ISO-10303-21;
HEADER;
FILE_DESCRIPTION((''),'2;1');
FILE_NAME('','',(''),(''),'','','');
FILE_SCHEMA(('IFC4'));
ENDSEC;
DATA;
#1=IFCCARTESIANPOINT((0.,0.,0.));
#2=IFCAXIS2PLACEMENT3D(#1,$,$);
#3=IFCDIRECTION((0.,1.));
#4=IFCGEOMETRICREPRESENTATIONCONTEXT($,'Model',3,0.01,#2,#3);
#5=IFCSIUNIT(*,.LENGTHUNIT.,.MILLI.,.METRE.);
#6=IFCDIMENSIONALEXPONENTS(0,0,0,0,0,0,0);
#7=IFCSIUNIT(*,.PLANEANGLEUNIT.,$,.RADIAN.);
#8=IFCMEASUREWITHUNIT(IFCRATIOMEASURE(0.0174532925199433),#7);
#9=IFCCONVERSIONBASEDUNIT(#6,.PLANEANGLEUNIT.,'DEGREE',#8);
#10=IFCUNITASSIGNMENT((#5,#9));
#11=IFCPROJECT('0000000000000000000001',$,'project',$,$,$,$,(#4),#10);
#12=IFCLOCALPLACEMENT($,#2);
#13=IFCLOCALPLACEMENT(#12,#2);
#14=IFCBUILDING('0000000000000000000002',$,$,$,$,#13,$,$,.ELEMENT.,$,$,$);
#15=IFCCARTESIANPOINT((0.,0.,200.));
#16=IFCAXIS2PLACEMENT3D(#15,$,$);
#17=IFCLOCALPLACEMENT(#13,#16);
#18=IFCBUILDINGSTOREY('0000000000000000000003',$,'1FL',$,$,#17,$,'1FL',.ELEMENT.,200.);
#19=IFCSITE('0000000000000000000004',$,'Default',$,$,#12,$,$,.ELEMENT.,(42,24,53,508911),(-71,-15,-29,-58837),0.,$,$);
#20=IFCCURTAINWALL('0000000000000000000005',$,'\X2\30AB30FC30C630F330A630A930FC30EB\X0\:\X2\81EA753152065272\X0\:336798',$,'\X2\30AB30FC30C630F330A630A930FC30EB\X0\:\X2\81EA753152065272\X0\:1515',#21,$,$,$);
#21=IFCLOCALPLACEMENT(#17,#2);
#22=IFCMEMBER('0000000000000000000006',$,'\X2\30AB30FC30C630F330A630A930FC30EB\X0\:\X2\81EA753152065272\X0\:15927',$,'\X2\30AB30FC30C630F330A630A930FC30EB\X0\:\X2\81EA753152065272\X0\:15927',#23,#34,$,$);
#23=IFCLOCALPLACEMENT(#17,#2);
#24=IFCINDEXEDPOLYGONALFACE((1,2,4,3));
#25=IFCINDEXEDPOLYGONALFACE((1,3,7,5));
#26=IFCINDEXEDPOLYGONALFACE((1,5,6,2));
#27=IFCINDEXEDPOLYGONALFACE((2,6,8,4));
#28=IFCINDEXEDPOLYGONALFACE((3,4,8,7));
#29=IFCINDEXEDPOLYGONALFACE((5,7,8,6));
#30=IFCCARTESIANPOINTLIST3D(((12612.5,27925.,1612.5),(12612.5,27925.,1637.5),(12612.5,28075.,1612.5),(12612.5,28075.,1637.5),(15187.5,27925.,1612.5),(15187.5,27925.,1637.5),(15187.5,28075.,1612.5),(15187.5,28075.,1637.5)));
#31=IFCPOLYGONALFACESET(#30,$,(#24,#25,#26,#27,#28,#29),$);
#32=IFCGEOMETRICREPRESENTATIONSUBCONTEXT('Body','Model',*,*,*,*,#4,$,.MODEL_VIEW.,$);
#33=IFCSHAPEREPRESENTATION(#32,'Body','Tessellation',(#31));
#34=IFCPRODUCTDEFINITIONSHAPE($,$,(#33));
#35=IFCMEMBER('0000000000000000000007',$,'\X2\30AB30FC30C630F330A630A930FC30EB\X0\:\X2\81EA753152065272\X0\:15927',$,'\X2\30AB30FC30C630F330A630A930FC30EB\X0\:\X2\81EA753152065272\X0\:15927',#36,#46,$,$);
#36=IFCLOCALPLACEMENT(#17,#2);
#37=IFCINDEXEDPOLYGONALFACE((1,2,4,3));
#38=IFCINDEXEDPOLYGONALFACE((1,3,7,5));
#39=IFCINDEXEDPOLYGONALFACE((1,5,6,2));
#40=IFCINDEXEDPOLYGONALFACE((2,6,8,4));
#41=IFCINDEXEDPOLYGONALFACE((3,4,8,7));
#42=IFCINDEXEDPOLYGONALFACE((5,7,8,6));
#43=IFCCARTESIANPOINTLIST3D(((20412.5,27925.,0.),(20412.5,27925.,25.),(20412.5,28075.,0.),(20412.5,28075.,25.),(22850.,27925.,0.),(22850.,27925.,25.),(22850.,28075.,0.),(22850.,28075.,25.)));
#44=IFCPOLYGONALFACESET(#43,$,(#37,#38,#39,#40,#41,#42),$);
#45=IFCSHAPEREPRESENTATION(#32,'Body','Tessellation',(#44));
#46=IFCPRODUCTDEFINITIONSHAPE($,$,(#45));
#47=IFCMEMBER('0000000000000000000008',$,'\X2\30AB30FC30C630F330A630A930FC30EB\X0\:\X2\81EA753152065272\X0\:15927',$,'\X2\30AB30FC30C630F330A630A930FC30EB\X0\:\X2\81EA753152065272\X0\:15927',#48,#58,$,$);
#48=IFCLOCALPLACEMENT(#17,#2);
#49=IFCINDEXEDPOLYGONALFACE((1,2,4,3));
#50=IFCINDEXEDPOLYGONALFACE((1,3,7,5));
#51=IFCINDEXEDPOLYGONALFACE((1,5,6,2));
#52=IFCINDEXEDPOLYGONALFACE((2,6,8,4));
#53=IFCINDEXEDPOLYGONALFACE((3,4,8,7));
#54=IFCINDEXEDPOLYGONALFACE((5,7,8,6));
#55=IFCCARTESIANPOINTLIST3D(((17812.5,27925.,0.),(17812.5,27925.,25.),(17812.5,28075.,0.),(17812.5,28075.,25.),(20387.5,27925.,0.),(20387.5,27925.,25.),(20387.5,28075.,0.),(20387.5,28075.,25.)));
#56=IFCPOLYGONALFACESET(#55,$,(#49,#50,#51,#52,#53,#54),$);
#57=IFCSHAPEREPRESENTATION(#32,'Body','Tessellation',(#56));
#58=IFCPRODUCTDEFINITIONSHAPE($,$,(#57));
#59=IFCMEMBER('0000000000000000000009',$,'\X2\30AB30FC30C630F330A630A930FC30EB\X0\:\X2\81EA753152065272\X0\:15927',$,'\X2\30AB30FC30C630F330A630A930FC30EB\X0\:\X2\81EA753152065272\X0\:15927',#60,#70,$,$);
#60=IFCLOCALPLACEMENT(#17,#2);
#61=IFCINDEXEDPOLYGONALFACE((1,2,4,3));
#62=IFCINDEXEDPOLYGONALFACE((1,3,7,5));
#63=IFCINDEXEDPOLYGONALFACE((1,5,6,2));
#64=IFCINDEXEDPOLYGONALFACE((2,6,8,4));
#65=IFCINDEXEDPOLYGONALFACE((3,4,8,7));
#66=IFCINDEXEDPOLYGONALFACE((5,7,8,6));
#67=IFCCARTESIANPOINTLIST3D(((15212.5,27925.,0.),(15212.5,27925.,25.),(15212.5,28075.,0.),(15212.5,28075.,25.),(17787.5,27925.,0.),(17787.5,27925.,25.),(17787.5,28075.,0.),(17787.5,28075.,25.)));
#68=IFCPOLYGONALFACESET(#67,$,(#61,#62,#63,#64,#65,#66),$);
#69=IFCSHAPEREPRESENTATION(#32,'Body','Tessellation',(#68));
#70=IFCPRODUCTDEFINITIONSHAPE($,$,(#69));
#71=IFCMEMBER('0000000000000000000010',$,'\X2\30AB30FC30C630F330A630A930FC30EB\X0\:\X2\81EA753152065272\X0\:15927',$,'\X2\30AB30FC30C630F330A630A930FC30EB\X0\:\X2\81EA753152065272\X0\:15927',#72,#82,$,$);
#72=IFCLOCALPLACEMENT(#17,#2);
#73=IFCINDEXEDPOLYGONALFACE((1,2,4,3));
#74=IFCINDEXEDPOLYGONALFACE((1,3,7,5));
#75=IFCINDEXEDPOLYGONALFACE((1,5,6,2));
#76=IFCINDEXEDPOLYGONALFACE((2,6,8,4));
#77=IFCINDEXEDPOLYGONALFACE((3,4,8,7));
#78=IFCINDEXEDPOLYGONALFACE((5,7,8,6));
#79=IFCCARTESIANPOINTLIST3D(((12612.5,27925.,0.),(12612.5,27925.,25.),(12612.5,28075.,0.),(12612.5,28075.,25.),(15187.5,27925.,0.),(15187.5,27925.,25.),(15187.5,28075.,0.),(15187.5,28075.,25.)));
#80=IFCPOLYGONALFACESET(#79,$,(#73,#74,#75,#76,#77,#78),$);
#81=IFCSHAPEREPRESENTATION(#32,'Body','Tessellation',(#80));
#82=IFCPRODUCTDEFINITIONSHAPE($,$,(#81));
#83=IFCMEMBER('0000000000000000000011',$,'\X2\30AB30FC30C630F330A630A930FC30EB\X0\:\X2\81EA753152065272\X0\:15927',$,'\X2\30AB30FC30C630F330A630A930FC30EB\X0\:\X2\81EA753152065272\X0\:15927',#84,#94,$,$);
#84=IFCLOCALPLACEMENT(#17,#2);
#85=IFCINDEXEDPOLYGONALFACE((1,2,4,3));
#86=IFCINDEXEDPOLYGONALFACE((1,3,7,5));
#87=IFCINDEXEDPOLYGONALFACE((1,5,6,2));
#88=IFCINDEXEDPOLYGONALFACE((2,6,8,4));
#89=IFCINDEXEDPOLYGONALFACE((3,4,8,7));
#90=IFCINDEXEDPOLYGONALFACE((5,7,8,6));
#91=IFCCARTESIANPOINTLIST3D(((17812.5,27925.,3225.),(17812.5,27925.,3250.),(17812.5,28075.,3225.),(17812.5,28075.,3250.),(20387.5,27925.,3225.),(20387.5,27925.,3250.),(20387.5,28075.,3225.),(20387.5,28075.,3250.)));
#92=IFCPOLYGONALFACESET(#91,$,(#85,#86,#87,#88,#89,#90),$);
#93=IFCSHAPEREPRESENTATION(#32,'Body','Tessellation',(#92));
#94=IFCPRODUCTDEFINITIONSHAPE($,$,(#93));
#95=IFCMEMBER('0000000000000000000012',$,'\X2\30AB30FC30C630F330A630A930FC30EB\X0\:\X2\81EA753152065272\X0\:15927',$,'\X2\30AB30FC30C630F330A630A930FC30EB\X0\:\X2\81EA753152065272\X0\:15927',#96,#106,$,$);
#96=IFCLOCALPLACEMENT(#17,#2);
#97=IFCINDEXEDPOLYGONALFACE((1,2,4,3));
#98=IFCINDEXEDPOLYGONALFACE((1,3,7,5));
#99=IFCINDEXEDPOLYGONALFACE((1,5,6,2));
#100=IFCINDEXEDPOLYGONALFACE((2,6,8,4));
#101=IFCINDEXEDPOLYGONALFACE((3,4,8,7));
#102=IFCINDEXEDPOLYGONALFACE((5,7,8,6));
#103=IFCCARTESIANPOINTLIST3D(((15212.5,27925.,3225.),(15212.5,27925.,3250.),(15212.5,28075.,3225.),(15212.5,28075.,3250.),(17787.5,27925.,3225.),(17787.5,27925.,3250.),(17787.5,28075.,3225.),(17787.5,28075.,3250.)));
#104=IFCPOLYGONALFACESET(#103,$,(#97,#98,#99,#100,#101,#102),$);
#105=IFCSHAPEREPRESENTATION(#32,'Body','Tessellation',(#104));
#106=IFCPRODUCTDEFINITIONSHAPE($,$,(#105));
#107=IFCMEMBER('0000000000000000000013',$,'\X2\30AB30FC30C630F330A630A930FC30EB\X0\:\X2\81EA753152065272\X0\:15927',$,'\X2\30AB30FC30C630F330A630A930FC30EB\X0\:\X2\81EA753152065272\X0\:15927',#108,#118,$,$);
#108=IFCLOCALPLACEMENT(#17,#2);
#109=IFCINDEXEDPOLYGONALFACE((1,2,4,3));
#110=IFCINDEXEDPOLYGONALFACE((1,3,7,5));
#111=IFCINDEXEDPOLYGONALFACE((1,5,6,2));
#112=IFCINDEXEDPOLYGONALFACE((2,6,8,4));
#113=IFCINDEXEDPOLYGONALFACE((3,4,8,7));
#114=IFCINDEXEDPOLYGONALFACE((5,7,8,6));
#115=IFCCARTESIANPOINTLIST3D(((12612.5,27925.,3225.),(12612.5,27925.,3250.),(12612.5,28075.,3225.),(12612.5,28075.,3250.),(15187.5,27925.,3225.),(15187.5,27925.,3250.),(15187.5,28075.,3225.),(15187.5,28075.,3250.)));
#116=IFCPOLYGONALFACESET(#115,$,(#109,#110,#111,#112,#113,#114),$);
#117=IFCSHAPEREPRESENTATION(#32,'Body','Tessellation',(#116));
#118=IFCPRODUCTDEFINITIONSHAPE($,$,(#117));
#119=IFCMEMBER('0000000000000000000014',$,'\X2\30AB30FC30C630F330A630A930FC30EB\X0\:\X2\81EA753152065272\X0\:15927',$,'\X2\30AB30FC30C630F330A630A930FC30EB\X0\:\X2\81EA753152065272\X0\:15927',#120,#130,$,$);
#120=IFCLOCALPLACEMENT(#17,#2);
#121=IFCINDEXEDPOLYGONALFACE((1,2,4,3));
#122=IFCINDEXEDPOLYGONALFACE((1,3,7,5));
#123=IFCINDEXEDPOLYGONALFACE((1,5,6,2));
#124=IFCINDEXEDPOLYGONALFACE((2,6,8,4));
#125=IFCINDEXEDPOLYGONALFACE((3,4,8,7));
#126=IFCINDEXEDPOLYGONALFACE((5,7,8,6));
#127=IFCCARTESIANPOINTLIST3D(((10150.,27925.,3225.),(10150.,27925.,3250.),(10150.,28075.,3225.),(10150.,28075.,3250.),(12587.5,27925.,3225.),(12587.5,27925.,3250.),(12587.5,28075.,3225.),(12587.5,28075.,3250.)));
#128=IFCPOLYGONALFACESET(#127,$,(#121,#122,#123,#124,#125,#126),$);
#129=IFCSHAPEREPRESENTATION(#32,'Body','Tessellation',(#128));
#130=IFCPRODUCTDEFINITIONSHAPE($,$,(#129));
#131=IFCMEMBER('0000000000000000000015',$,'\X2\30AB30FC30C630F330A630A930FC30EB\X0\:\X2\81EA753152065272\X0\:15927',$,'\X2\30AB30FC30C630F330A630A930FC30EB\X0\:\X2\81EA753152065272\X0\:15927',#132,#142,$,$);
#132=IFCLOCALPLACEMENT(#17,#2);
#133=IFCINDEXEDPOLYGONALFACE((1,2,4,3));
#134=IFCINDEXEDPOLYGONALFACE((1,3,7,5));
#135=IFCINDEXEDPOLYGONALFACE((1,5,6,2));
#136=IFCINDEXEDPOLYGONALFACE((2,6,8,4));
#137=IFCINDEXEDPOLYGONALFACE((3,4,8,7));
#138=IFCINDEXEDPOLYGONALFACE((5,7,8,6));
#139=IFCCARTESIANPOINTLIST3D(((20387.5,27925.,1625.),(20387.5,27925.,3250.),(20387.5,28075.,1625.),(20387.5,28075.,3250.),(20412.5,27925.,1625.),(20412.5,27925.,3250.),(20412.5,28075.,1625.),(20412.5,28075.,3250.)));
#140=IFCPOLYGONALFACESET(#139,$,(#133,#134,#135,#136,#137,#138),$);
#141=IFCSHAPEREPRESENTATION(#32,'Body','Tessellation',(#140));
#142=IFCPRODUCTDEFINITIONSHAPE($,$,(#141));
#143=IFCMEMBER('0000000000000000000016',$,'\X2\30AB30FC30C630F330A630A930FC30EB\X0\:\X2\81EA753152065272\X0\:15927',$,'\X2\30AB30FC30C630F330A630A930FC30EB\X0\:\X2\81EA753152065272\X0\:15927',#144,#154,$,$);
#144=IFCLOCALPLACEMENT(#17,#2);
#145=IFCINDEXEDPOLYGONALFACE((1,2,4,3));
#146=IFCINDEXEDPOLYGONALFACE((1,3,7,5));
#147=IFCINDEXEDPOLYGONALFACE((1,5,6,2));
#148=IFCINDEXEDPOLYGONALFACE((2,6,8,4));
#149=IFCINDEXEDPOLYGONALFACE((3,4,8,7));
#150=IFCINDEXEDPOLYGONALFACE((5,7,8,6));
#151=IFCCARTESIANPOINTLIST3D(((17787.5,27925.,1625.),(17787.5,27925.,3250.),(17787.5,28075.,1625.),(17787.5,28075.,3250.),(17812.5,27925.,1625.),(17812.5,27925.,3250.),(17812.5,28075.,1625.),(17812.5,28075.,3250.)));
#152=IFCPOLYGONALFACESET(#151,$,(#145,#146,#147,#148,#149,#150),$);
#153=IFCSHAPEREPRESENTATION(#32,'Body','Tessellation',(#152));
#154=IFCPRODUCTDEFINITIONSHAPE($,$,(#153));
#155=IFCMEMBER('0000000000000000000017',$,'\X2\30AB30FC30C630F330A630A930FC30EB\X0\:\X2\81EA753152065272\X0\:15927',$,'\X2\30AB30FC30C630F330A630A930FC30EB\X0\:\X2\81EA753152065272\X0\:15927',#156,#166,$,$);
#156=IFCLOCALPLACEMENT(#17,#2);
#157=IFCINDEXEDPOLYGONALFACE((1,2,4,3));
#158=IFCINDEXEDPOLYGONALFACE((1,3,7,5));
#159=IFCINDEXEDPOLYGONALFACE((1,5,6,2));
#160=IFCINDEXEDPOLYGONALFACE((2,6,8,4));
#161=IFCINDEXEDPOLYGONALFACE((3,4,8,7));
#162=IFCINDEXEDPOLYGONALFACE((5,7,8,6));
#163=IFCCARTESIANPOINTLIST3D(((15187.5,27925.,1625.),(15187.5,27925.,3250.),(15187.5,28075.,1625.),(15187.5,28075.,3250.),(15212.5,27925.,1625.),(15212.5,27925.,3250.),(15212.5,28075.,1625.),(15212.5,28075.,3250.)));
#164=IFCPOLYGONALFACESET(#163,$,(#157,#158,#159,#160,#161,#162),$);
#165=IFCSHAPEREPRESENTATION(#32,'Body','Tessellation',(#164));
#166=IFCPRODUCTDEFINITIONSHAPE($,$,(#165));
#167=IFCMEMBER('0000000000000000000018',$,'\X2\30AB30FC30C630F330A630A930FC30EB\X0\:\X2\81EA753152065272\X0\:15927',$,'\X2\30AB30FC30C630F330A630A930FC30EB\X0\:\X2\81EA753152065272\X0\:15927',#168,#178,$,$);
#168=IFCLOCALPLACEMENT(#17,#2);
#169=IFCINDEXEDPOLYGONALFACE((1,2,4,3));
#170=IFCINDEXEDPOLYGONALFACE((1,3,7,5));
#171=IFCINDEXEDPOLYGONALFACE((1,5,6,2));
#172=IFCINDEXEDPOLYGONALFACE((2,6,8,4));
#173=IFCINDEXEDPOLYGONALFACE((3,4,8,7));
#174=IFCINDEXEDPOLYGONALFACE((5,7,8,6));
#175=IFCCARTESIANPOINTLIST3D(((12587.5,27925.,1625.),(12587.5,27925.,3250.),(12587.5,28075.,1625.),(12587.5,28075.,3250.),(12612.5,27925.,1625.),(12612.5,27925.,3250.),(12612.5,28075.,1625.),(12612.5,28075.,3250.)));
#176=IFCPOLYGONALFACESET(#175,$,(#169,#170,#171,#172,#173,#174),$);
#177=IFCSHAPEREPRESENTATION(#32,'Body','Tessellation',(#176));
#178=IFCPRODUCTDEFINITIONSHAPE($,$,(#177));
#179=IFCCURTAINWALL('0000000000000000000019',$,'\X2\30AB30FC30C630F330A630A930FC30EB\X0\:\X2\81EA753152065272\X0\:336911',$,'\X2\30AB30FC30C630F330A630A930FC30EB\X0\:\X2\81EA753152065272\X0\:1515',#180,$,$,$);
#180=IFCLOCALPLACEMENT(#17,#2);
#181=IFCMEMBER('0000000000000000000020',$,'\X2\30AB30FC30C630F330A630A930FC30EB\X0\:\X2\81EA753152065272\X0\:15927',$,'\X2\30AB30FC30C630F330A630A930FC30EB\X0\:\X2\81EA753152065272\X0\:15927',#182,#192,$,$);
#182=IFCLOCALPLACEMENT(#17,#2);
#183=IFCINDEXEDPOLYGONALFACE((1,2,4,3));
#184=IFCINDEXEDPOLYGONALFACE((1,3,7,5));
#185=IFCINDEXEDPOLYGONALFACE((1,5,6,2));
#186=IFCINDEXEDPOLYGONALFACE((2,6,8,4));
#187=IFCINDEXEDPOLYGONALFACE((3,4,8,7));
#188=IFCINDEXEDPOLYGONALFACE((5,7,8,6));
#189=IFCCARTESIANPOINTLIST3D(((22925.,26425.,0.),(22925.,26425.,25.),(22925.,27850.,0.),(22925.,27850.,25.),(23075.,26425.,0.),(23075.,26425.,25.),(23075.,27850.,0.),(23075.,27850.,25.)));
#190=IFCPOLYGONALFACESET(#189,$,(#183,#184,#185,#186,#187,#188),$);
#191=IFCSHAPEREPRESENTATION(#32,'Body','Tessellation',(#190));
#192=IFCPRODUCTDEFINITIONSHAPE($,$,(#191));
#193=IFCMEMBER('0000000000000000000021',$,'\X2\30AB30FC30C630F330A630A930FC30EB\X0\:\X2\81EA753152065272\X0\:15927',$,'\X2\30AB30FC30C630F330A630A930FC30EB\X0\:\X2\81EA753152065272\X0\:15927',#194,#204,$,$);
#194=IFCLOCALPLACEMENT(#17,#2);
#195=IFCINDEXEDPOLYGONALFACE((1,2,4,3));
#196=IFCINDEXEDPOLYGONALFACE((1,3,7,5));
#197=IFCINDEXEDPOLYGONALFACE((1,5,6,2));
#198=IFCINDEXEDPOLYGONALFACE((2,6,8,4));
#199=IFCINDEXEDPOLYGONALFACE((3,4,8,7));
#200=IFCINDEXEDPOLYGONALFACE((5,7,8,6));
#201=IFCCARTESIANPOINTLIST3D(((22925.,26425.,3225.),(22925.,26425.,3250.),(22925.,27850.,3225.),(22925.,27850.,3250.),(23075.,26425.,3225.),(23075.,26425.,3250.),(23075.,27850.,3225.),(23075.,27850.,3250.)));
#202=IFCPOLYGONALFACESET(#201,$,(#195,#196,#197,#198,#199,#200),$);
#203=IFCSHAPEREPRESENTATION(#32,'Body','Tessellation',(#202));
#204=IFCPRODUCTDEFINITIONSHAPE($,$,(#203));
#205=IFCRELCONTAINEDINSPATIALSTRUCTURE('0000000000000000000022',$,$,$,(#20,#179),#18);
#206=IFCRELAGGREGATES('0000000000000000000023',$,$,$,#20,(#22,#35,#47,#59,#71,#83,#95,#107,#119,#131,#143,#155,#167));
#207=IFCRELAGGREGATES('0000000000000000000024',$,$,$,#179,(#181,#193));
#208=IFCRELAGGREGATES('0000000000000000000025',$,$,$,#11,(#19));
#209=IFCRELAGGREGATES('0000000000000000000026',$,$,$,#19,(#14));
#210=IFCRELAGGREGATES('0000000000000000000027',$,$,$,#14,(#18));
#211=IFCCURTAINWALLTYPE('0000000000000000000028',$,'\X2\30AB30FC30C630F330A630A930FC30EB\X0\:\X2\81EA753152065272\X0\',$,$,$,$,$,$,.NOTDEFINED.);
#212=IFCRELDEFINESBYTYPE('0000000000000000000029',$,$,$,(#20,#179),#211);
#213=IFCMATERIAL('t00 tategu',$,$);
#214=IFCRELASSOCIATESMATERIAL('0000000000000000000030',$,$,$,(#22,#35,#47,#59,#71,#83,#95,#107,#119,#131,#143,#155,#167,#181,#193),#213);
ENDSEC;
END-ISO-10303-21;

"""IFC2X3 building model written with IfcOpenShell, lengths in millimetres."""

from ifc_helpers import new_model, entity, si_unit, converted_unit, direction, frame, frame_2d, origin, origin_2d_with_axis, place, context, subcontext, project, spatial, rectangle, extrude, material, type_object, element, aggregate, save


model = new_model("IFC2X3")

# Units and contexts
model_context = context("Model", 3, precision=0.01, world=origin(), true_north=direction((0.0, 1.0)))
body_context = subcontext(model_context, "Body", "Model", "MODEL_VIEW")
ifc_project = project(units=[si_unit("LENGTHUNIT", "METRE", prefix="MILLI"), converted_unit("PLANEANGLEUNIT", "DEGREE", entity("IfcRatioMeasure", 0.0174532925199433), si_unit("PLANEANGLEUNIT", "RADIAN"), dimensions=[0, 0, 0, 0, 0, 0, 0])], contexts=[model_context])

# Site, building, storey
site_placement = place(None, origin())
site = spatial("IfcSite", under=ifc_project, at=site_placement, Name="Default", CompositionType="ELEMENT", RefLatitude=(42, 24, 53, 508911), RefLongitude=(-71, -15, -29, -58837), RefElevation=0.0)
building_placement = place(site_placement, origin())
building = spatial("IfcBuilding", under=site, at=building_placement, CompositionType="ELEMENT")
storey_placement = place(building_placement, frame((0.0, 0.0, 200.0)))
storey = spatial("IfcBuildingStorey", under=building, at=storey_placement, Name="1FL", LongName="1FL", CompositionType="ELEMENT", Elevation=200.0)

# Curtain walls, members
curtain_wall_type = type_object("IfcCurtainWallType", Name="カーテンウォール:自由分割", PredefinedType="NOTDEFINED")
curtain_wall_1_placement = place(storey_placement, frame((0.0, 0.0, -200.0)))
curtain_wall_1 = element("IfcCurtainWall", 1, at=curtain_wall_1_placement, inside=storey, type_object=curtain_wall_type, Name="カーテンウォール:自由分割:336798", ObjectType="カーテンウォール:自由分割:1515")
ifc_material = material(Name="t00 tategu")
member_1_placement = place(curtain_wall_1_placement, frame((0.0, 0.0, 200.0)))
member_1 = element("IfcMember", 2, at=member_1_placement, material=ifc_material, Name="カーテンウォール:自由分割:15927", ObjectType="カーテンウォール:自由分割:15927", context=body_context, shape_type="SweptSolid", body=[
    extrude(rectangle(XDim=25.0, YDim=150.0, at=frame_2d((0.0, 0.0), x_axis=(1.0, 0.0))), frame((15187.5, 28000.0, 1625.0), z_axis=(-1.0, 0.0, 0.0), x_axis=(0.0, 0.0, -1.0)), (0.0, 0.0, 1.0), 2575.0),
])
member_2_placement = place(curtain_wall_1_placement, frame((0.0, 0.0, 200.0)))
member_2 = element("IfcMember", 3, at=member_2_placement, material=ifc_material, Name="カーテンウォール:自由分割:15927", ObjectType="カーテンウォール:自由分割:15927", context=body_context, shape_type="SweptSolid", body=[
    extrude(rectangle(XDim=25.0, YDim=150.0, at=frame_2d((0.0, 0.0), x_axis=(1.0, 0.0))), frame((20412.5, 28000.0, 12.5), z_axis=(1.0, 0.0, 0.0), x_axis=(0.0, 0.0, -1.0)), (0.0, 0.0, 1.0), 2437.5),
])
member_3_placement = place(curtain_wall_1_placement, frame((0.0, 0.0, 200.0)))
member_3 = element("IfcMember", 4, at=member_3_placement, material=ifc_material, Name="カーテンウォール:自由分割:15927", ObjectType="カーテンウォール:自由分割:15927", context=body_context, shape_type="SweptSolid", body=[
    extrude(rectangle(XDim=25.0, YDim=150.0, at=frame_2d((0.0, 0.0), x_axis=(1.0, 0.0))), frame((17812.5, 28000.0, 12.5), z_axis=(1.0, 0.0, 0.0), x_axis=(0.0, 0.0, -1.0)), (0.0, 0.0, 1.0), 2575.0),
])
member_4_placement = place(curtain_wall_1_placement, frame((0.0, 0.0, 200.0)))
member_4 = element("IfcMember", 5, at=member_4_placement, material=ifc_material, Name="カーテンウォール:自由分割:15927", ObjectType="カーテンウォール:自由分割:15927", context=body_context, shape_type="SweptSolid", body=[
    extrude(rectangle(XDim=25.0, YDim=150.0, at=frame_2d((0.0, 0.0), x_axis=(1.0, 0.0))), frame((15212.5, 28000.0, 12.5), z_axis=(1.0, 0.0, 0.0), x_axis=(0.0, 0.0, -1.0)), (0.0, 0.0, 1.0), 2575.0),
])
member_5_placement = place(curtain_wall_1_placement, frame((0.0, 0.0, 200.0)))
member_5 = element("IfcMember", 6, at=member_5_placement, material=ifc_material, Name="カーテンウォール:自由分割:15927", ObjectType="カーテンウォール:自由分割:15927", context=body_context, shape_type="SweptSolid", body=[
    extrude(rectangle(XDim=25.0, YDim=150.0, at=frame_2d((0.0, 0.0), x_axis=(1.0, 0.0))), frame((12612.5, 28000.0, 12.5), z_axis=(1.0, 0.0, 0.0), x_axis=(0.0, 0.0, -1.0)), (0.0, 0.0, 1.0), 2575.0),
])
member_6_placement = place(curtain_wall_1_placement, frame((0.0, 0.0, 200.0)))
member_6 = element("IfcMember", 7, at=member_6_placement, material=ifc_material, Name="カーテンウォール:自由分割:15927", ObjectType="カーテンウォール:自由分割:15927", context=body_context, shape_type="SweptSolid", body=[
    extrude(rectangle(XDim=25.0, YDim=150.0, at=frame_2d((0.0, 0.0), x_axis=(1.0, 0.0))), frame((20387.5, 28000.0, 3237.5), z_axis=(-1.0, 0.0, 0.0), x_axis=(0.0, 0.0, -1.0)), (0.0, 0.0, 1.0), 2575.0),
])
member_7_placement = place(curtain_wall_1_placement, frame((0.0, 0.0, 200.0)))
member_7 = element("IfcMember", 8, at=member_7_placement, material=ifc_material, Name="カーテンウォール:自由分割:15927", ObjectType="カーテンウォール:自由分割:15927", context=body_context, shape_type="SweptSolid", body=[
    extrude(rectangle(XDim=25.0, YDim=150.0, at=frame_2d((0.0, 0.0), x_axis=(1.0, 0.0))), frame((17787.5, 28000.0, 3237.5), z_axis=(-1.0, 0.0, 0.0), x_axis=(0.0, 0.0, -1.0)), (0.0, 0.0, 1.0), 2575.0),
])
member_8_placement = place(curtain_wall_1_placement, frame((0.0, 0.0, 200.0)))
member_8 = element("IfcMember", 9, at=member_8_placement, material=ifc_material, Name="カーテンウォール:自由分割:15927", ObjectType="カーテンウォール:自由分割:15927", context=body_context, shape_type="SweptSolid", body=[
    extrude(rectangle(XDim=25.0, YDim=150.0, at=frame_2d((0.0, 0.0), x_axis=(1.0, 0.0))), frame((15187.5, 28000.0, 3237.5), z_axis=(-1.0, 0.0, 0.0), x_axis=(0.0, 0.0, -1.0)), (0.0, 0.0, 1.0), 2575.0),
])
member_9_placement = place(curtain_wall_1_placement, frame((0.0, 0.0, 200.0)))
member_9 = element("IfcMember", 10, at=member_9_placement, material=ifc_material, Name="カーテンウォール:自由分割:15927", ObjectType="カーテンウォール:自由分割:15927", context=body_context, shape_type="SweptSolid", body=[
    extrude(rectangle(XDim=25.0, YDim=150.0, at=frame_2d((0.0, 0.0), x_axis=(1.0, 0.0))), frame((12587.5, 28000.0, 3237.5), z_axis=(-1.0, 0.0, 0.0), x_axis=(0.0, 0.0, -1.0)), (0.0, 0.0, 1.0), 2437.5),
])
member_10_placement = place(curtain_wall_1_placement, frame((0.0, 0.0, 200.0)))
member_10 = element("IfcMember", 11, at=member_10_placement, material=ifc_material, Name="カーテンウォール:自由分割:15927", ObjectType="カーテンウォール:自由分割:15927", context=body_context, shape_type="SweptSolid", body=[
    extrude(rectangle(XDim=25.0, YDim=150.0, at=origin_2d_with_axis()), frame((20400.0, 28000.0, 1625.0), z_axis=(0.0, 0.0, 1.0), x_axis=(-1.0, 0.0, 0.0)), (0.0, 0.0, 1.0), 1625.0),
])
member_11_placement = place(curtain_wall_1_placement, frame((0.0, 0.0, 200.0)))
member_11 = element("IfcMember", 12, at=member_11_placement, material=ifc_material, Name="カーテンウォール:自由分割:15927", ObjectType="カーテンウォール:自由分割:15927", context=body_context, shape_type="SweptSolid", body=[
    extrude(rectangle(XDim=25.0, YDim=150.0, at=origin_2d_with_axis()), frame((17800.0, 28000.0, 1625.0), z_axis=(0.0, 0.0, 1.0), x_axis=(-1.0, 0.0, 0.0)), (0.0, 0.0, 1.0), 1625.0),
])
member_12_placement = place(curtain_wall_1_placement, frame((0.0, 0.0, 200.0)))
member_12 = element("IfcMember", 13, at=member_12_placement, material=ifc_material, Name="カーテンウォール:自由分割:15927", ObjectType="カーテンウォール:自由分割:15927", context=body_context, shape_type="SweptSolid", body=[
    extrude(rectangle(XDim=25.0, YDim=150.0, at=origin_2d_with_axis()), frame((15200.0, 28000.0, 1625.0), z_axis=(0.0, 0.0, 1.0), x_axis=(-1.0, 0.0, 0.0)), (0.0, 0.0, 1.0), 1625.0),
])
member_13_placement = place(curtain_wall_1_placement, frame((0.0, 0.0, 200.0)))
member_13 = element("IfcMember", 14, at=member_13_placement, material=ifc_material, Name="カーテンウォール:自由分割:15927", ObjectType="カーテンウォール:自由分割:15927", context=body_context, shape_type="SweptSolid", body=[
    extrude(rectangle(XDim=25.0, YDim=150.0, at=origin_2d_with_axis()), frame((12600.0, 28000.0, 1625.0), z_axis=(0.0, 0.0, 1.0), x_axis=(-1.0, 0.0, 0.0)), (0.0, 0.0, 1.0), 1625.0),
])
aggregate(curtain_wall_1, [member_1, member_2, member_3, member_4, member_5, member_6, member_7, member_8, member_9, member_10, member_11, member_12, member_13])
curtain_wall_2_placement = place(storey_placement, frame((0.0, 0.0, -200.0)))
curtain_wall_2 = element("IfcCurtainWall", 15, at=curtain_wall_2_placement, inside=storey, type_object=curtain_wall_type, Name="カーテンウォール:自由分割:336911", ObjectType="カーテンウォール:自由分割:1515")
member_14_placement = place(curtain_wall_2_placement, frame((0.0, 0.0, 200.0)))
member_14 = element("IfcMember", 16, at=member_14_placement, material=ifc_material, Name="カーテンウォール:自由分割:15927", ObjectType="カーテンウォール:自由分割:15927", context=body_context, shape_type="SweptSolid", body=[
    extrude(rectangle(XDim=25.0, YDim=150.0, at=origin_2d_with_axis()), frame((23000.0, 27850.0, 12.5), z_axis=(0.0, -1.0, 0.0), x_axis=(0.0, 0.0, -1.0)), (0.0, 0.0, 1.0), 1425.0),
])
member_15_placement = place(curtain_wall_2_placement, frame((0.0, 0.0, 200.0)))
member_15 = element("IfcMember", 17, at=member_15_placement, material=ifc_material, Name="カーテンウォール:自由分割:15927", ObjectType="カーテンウォール:自由分割:15927", context=body_context, shape_type="SweptSolid", body=[
    extrude(rectangle(XDim=25.0, YDim=150.0, at=frame_2d((0.0, 0.0), x_axis=(1.0, 0.0))), frame((23000.0, 26425.0, 3237.5), z_axis=(0.0, 1.0, 0.0), x_axis=(0.0, 0.0, -1.0)), (0.0, 0.0, 1.0), 1425.0),
])
aggregate(curtain_wall_2, [member_14, member_15])

save(model, "model.ifc")
